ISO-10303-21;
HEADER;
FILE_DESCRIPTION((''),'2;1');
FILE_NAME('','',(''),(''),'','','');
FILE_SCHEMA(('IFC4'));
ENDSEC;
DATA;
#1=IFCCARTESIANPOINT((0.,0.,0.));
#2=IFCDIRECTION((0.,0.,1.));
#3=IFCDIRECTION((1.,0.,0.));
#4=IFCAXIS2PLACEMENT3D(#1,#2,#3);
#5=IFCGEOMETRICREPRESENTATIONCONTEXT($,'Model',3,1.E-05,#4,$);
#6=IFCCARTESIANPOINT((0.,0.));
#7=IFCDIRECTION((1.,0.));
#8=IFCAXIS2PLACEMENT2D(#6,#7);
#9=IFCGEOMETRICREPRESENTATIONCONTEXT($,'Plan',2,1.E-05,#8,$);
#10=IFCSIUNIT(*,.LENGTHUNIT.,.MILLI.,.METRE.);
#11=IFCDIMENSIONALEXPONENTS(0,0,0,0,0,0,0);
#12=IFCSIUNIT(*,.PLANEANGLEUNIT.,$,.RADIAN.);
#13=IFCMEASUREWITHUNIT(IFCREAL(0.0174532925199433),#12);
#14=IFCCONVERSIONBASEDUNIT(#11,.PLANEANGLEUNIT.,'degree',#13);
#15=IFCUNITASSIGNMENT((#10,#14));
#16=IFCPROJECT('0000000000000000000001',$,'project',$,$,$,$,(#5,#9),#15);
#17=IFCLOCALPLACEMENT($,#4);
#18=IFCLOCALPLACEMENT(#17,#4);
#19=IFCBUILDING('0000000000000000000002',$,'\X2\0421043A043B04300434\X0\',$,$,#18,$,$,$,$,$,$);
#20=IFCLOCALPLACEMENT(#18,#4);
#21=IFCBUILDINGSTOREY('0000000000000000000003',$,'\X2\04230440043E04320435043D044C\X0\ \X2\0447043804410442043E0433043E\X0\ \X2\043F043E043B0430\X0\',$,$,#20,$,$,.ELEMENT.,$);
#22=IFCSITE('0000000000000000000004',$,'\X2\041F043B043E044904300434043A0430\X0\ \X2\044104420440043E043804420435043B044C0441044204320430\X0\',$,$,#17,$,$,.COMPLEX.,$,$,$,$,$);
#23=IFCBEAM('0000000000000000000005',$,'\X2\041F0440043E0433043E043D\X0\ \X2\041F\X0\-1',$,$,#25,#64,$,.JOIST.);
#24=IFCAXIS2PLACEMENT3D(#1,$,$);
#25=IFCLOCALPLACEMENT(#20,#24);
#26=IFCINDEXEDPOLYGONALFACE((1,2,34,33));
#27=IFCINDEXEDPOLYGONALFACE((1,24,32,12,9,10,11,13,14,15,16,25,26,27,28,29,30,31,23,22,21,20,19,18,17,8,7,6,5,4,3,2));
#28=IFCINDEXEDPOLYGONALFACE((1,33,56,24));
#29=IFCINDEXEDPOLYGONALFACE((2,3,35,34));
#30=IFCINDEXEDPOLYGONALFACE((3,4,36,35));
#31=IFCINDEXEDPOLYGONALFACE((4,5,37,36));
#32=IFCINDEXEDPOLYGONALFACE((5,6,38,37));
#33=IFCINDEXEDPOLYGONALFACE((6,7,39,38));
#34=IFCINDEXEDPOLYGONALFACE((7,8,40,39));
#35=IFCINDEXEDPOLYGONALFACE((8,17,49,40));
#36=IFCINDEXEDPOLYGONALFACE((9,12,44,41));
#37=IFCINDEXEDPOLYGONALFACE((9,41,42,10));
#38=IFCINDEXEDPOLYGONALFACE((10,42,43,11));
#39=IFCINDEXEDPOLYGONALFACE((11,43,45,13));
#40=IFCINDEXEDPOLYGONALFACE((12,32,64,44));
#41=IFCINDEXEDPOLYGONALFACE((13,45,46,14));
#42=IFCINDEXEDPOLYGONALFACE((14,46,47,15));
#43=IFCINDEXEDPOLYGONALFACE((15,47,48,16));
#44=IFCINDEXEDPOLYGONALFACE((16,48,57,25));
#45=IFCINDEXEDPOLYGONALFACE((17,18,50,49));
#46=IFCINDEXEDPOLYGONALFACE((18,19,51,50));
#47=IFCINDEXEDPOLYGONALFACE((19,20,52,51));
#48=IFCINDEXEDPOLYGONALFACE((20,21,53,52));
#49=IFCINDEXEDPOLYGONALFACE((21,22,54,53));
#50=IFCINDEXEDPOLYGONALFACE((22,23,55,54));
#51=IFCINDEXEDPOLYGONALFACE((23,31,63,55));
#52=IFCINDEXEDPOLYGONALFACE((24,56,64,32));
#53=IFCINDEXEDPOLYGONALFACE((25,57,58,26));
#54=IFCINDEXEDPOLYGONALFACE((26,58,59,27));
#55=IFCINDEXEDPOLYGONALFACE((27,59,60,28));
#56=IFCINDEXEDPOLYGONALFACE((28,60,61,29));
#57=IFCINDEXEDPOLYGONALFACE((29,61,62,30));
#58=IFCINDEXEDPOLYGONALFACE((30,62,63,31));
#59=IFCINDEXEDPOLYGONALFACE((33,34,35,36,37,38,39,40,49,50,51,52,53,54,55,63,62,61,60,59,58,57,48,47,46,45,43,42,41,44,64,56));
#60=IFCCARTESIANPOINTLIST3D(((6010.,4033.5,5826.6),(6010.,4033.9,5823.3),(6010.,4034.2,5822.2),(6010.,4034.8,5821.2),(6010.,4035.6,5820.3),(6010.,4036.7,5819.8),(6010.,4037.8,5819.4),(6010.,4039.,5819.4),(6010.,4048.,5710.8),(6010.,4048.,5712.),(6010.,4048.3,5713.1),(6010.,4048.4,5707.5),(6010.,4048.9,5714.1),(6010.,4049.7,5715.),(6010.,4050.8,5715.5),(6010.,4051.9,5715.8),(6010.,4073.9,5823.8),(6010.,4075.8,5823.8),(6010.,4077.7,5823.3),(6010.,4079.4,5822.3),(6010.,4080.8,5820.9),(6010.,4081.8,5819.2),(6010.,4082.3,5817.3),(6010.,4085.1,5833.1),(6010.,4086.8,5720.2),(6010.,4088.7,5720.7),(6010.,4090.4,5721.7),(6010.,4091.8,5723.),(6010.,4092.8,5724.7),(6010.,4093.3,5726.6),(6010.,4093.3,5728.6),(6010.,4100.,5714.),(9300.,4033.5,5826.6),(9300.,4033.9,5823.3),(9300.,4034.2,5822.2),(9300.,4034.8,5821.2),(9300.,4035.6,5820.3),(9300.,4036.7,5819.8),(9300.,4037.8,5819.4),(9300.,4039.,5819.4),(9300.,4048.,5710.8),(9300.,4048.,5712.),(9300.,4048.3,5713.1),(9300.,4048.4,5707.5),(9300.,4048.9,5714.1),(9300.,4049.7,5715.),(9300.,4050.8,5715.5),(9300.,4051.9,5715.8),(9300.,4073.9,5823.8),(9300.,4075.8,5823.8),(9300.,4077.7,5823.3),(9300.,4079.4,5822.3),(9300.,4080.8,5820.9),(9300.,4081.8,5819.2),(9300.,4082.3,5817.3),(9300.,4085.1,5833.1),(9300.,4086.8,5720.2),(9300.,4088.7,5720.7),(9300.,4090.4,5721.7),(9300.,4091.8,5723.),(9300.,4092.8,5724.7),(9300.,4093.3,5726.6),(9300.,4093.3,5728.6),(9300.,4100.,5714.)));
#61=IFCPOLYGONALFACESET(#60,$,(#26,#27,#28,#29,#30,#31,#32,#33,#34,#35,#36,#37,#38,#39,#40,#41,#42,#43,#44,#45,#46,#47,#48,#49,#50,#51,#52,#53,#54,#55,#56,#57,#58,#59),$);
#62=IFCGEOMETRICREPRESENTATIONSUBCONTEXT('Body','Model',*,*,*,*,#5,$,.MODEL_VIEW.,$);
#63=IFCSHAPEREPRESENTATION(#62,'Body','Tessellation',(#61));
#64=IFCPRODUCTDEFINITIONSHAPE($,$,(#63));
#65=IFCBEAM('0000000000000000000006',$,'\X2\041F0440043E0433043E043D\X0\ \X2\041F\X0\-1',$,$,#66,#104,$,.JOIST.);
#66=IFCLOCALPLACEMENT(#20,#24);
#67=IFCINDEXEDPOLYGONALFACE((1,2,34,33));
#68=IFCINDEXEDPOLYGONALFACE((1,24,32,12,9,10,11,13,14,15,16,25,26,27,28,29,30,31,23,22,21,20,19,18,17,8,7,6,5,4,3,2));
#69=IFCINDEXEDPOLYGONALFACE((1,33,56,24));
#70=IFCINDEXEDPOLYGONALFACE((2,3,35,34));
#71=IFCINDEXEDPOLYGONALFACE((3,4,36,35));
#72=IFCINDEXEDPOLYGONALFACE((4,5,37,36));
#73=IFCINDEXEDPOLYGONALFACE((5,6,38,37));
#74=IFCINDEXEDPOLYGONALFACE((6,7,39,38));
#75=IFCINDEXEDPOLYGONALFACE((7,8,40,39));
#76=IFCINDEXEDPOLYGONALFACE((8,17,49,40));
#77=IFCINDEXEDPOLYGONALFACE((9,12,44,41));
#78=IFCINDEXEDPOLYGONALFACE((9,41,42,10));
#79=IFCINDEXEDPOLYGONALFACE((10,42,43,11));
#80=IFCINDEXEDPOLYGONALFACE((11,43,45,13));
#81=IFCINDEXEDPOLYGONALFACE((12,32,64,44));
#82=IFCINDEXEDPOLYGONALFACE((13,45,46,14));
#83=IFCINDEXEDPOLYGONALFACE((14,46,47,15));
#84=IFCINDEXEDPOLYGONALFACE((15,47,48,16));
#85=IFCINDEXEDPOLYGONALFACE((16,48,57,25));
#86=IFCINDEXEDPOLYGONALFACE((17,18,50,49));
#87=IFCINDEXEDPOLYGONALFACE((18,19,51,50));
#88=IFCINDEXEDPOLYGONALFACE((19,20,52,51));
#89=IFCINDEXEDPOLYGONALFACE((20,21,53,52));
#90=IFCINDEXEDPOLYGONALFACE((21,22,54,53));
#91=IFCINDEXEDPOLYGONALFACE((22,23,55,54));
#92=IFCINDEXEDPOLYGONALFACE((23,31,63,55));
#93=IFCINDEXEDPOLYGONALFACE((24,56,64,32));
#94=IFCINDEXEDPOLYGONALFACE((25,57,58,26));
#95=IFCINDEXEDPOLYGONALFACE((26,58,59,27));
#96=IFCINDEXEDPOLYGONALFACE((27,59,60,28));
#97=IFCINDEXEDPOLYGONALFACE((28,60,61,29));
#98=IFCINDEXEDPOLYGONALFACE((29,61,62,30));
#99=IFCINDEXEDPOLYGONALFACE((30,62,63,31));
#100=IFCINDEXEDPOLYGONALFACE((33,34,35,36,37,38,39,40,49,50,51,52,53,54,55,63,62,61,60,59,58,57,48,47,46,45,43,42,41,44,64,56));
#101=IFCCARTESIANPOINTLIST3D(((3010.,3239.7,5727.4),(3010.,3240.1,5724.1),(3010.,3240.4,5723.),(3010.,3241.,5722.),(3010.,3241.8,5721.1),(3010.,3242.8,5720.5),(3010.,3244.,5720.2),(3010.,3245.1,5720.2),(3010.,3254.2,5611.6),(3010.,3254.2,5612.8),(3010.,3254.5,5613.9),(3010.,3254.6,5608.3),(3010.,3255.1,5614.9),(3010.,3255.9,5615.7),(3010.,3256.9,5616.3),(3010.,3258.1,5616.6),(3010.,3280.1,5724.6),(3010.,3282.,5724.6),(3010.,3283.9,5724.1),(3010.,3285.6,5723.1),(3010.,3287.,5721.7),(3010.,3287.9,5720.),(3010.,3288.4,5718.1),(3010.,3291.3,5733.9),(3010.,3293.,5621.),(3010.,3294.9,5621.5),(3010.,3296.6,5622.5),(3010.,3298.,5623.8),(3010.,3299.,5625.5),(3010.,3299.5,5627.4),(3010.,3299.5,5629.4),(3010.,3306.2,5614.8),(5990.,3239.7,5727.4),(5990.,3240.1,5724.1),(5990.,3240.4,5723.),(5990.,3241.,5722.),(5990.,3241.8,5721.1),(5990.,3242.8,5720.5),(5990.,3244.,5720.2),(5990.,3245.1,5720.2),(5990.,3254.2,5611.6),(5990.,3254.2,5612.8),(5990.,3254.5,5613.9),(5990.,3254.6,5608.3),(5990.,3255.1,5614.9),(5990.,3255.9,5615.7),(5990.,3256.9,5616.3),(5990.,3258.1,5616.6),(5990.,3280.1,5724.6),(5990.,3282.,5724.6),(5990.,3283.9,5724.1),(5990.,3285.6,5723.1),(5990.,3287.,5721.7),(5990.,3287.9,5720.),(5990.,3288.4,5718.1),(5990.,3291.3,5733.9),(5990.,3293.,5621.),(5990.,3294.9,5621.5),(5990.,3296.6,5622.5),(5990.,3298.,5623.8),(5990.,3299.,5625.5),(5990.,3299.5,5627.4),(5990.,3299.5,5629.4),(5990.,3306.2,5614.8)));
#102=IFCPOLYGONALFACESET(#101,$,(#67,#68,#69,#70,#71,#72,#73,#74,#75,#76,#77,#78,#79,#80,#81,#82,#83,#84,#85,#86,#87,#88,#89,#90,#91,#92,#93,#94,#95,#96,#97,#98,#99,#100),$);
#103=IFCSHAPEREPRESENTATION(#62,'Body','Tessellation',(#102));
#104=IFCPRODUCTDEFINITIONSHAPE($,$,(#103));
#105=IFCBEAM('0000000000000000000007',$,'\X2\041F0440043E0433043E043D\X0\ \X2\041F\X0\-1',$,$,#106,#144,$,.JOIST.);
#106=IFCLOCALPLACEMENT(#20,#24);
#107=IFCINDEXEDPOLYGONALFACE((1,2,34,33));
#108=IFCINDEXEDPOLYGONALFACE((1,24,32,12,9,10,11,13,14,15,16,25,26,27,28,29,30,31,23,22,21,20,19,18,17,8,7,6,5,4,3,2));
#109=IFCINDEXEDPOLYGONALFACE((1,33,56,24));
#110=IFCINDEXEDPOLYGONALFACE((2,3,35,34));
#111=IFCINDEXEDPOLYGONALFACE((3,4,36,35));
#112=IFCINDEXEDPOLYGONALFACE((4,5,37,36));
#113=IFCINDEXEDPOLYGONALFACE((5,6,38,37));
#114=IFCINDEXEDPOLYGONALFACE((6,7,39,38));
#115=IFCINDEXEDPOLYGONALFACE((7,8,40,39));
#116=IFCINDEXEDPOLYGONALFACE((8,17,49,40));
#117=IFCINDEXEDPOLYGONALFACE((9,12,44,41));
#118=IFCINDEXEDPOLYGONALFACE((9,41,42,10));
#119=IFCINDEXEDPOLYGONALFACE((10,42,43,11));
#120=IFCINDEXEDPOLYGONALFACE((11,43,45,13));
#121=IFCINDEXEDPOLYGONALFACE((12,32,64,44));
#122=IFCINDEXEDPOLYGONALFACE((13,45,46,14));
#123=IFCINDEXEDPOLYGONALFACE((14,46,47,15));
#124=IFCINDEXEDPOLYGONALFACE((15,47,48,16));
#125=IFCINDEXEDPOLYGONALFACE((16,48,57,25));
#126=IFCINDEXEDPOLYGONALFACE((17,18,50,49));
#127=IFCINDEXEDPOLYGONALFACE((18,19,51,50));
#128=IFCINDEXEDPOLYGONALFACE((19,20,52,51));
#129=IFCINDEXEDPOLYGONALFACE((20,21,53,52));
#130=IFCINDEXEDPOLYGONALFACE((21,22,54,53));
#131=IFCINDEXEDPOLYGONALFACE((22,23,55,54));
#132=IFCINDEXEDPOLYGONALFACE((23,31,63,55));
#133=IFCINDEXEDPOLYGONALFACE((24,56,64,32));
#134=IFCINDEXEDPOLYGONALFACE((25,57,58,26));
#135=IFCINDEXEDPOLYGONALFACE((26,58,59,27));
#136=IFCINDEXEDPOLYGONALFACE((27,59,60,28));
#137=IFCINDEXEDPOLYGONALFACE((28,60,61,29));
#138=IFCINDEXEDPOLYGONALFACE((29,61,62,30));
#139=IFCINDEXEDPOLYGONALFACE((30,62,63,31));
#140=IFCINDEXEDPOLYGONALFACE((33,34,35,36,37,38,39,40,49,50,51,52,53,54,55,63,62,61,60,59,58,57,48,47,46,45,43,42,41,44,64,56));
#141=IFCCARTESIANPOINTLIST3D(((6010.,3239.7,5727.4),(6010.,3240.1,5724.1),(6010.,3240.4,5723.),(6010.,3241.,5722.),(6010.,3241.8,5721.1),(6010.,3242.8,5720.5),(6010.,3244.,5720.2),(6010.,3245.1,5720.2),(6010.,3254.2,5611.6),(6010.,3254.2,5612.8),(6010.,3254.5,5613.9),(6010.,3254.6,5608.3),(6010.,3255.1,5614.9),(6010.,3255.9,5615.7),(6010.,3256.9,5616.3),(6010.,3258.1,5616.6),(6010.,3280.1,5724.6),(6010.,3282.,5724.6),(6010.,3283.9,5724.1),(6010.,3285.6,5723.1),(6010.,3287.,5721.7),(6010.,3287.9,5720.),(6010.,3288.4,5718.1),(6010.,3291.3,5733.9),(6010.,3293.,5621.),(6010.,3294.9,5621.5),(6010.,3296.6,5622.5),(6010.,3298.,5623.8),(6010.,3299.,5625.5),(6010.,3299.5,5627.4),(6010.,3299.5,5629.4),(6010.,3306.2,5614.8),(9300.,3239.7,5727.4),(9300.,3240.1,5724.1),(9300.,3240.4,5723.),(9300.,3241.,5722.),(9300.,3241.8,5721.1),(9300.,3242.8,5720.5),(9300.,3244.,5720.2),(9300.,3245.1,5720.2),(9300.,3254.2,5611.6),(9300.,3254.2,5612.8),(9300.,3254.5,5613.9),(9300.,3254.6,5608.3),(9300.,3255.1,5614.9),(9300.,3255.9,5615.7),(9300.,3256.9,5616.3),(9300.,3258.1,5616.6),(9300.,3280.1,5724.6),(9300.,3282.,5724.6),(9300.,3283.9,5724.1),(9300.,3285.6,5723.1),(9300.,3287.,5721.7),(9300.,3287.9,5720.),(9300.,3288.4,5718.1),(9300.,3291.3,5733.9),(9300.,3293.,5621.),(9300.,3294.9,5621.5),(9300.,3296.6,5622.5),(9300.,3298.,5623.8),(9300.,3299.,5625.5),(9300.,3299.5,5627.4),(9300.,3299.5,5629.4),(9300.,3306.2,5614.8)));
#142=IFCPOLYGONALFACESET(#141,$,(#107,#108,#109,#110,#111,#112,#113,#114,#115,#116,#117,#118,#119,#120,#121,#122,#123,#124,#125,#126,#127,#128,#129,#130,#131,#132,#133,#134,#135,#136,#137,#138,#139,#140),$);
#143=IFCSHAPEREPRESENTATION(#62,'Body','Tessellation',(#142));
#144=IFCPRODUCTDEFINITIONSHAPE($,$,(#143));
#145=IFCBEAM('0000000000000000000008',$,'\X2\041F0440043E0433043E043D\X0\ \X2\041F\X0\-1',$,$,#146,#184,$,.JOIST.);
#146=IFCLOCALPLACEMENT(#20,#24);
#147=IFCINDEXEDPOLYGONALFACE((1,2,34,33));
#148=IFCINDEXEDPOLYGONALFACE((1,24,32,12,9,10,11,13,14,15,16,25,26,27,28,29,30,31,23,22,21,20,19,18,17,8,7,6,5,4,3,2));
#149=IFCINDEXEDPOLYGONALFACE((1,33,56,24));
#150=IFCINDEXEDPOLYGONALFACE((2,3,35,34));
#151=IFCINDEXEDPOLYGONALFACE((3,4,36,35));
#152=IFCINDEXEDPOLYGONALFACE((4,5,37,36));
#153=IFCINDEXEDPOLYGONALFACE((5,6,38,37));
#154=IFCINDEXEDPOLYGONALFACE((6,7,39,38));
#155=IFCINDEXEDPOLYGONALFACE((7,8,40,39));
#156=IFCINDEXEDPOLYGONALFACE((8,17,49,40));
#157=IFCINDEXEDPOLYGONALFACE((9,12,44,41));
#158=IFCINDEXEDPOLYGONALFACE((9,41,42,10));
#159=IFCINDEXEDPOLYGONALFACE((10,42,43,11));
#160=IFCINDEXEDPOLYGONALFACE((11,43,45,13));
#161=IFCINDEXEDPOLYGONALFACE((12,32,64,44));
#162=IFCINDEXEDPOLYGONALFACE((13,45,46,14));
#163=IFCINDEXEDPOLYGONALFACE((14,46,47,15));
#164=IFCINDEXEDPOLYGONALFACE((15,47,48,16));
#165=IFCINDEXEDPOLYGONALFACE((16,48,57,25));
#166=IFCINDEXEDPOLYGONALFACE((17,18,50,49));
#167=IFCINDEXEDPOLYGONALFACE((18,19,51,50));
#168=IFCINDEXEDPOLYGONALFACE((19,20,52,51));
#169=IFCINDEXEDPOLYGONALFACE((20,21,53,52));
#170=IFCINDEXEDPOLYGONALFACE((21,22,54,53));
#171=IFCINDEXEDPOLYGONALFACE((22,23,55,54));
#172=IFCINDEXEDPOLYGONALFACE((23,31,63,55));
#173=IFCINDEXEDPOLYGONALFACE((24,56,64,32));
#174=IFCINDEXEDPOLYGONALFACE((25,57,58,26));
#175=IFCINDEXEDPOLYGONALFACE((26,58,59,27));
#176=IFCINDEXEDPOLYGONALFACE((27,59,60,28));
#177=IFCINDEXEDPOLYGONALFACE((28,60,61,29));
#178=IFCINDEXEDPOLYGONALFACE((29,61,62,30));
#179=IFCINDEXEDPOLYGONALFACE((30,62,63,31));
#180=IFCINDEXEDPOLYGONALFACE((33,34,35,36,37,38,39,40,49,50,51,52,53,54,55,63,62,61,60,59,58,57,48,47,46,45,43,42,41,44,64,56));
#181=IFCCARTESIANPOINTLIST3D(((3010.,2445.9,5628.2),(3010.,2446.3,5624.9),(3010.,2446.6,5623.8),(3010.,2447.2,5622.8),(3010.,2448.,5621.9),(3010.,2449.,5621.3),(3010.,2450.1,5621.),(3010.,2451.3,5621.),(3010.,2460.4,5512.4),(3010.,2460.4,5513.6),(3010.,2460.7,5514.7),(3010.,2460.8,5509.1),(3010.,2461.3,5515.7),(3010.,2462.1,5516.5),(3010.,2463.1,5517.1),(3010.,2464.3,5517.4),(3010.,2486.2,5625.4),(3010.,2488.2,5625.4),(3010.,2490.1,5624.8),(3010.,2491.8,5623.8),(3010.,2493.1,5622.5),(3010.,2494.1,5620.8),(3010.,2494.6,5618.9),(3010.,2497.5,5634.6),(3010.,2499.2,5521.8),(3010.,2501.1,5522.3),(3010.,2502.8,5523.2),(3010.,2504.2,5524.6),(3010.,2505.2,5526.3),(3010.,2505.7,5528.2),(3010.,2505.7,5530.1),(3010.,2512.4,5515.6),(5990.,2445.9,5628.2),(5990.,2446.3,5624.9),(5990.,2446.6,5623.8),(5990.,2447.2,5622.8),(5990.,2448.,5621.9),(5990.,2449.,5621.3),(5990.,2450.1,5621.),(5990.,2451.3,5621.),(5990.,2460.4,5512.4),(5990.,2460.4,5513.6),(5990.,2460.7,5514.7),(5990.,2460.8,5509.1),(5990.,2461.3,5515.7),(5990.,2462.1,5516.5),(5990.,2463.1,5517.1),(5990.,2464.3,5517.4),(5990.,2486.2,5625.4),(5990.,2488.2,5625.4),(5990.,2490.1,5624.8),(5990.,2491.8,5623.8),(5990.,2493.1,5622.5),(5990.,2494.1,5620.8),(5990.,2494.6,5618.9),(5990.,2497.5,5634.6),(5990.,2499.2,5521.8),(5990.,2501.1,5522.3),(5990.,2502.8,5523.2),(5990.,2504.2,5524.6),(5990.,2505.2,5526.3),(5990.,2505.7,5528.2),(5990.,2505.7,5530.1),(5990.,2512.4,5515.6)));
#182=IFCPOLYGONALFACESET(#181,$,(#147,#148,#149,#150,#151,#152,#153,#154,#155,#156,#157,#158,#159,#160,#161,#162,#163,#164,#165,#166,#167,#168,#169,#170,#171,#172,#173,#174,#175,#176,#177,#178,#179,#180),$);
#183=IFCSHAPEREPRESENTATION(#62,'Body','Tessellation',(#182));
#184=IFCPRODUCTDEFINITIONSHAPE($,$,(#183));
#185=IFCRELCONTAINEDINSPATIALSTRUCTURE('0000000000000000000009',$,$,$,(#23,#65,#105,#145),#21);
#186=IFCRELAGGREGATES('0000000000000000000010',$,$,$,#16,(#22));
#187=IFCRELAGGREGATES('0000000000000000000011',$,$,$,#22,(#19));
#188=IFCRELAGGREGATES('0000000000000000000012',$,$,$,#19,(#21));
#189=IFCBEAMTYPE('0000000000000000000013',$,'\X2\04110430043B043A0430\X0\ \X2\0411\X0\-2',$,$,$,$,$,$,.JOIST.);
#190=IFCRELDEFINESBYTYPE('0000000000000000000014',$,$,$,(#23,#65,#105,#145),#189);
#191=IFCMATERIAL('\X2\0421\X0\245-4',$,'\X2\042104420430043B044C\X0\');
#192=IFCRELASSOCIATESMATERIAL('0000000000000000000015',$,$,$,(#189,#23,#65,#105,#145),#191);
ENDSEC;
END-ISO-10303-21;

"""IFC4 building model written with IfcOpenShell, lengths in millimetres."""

from ifc_helpers import new_model, entity, si_unit, converted_unit, frame, origin_with_axes, origin_2d_with_axis, place, context, subcontext, project, spatial, u_section, extrude, material, material_profile, profile_set, profile_usage, type_object, element, save


model = new_model("IFC4")

# Units and contexts
model_context = context("Model", 3, precision=1e-05, world=origin_with_axes())
plan_context = context("Plan", 2, precision=1e-05, world=origin_2d_with_axis())
body_context = subcontext(model_context, "Body", "Model", "MODEL_VIEW")
ifc_project = project(units=[si_unit("LENGTHUNIT", "METRE", prefix="MILLI"), converted_unit("PLANEANGLEUNIT", "degree", entity("IfcReal", 0.0174532925199433), si_unit("PLANEANGLEUNIT", "RADIAN"), dimensions=[0, 0, 0, 0, 0, 0, 0])], contexts=[model_context, plan_context])

# Site, building, storey
site_placement = place(None, origin_with_axes())
site = spatial("IfcSite", under=ifc_project, at=site_placement, Name="Площадка строительства", CompositionType="COMPLEX")
building_placement = place(site_placement, origin_with_axes())
building = spatial("IfcBuilding", under=site, at=building_placement, Name="Склад")
storey_placement = place(building_placement, origin_with_axes())
storey = spatial("IfcBuildingStorey", under=building, at=storey_placement, Name="Уровень чистого пола", CompositionType="ELEMENT")

# Beams
ifc_material_1 = material(Name="С245-4", Category="Сталь")
ifc_material_profile_1 = material_profile(ifc_material_1, u_section(Depth=120.0, FlangeWidth=52.0, WebThickness=4.8, FlangeThickness=7.8, FilletRadius=7.5, EdgeRadius=4.5, FlangeSlope=0.0))
ifc_profile_set_1 = profile_set([ifc_material_profile_1], Name="U12P_S245-4")
beam_type_1 = type_object("IfcBeamType", Name="Балка Б-2", PredefinedType="JOIST", material=ifc_profile_set_1)
ifc_profile_usage_1 = profile_usage(ifc_profile_set_1, cardinal=3)
beam_1_placement = place(storey_placement, frame((9300.0, 4100.0, 5714.0), z_axis=(-1.0, 0.0, 0.0), x_axis=(0.0, -0.99228, -0.12402)))
element("IfcBeam", 1, at=beam_1_placement, inside=storey, type_object=beam_type_1, material=ifc_profile_usage_1, Name="Прогон П-1", PredefinedType="JOIST", context=body_context, shape_type="SweptSolid", body=[
    extrude(u_section(Depth=120.0, FlangeWidth=52.0, WebThickness=4.8, FlangeThickness=7.8, FilletRadius=7.5, EdgeRadius=4.5, FlangeSlope=0.0), frame((26.0, 60.0, 0.0), z_axis=(0.0, 0.0, 1.0), x_axis=(1.0, 0.0, 0.0)), (0.0, 0.0, 1.0), 3290.0),
])
ifc_profile_usage_2 = profile_usage(ifc_profile_set_1, cardinal=3)
beam_2_placement = place(storey_placement, frame((5990.0, 3306.2, 5614.8), z_axis=(-1.0, 0.0, 0.0), x_axis=(0.0, -0.99228, -0.12402)))
element("IfcBeam", 2, at=beam_2_placement, inside=storey, type_object=beam_type_1, material=ifc_profile_usage_2, Name="Прогон П-1", PredefinedType="JOIST", context=body_context, shape_type="SweptSolid", body=[
    extrude(u_section(Depth=120.0, FlangeWidth=52.0, WebThickness=4.8, FlangeThickness=7.8, FilletRadius=7.5, EdgeRadius=4.5, FlangeSlope=0.0), frame((26.0, 60.0, 0.0), z_axis=(0.0, 0.0, 1.0), x_axis=(1.0, 0.0, 0.0)), (0.0, 0.0, 1.0), 2980.0),
])
ifc_profile_usage_3 = profile_usage(ifc_profile_set_1, cardinal=3)
beam_3_placement = place(storey_placement, frame((9300.0, 3306.2, 5614.8), z_axis=(-1.0, 0.0, 0.0), x_axis=(0.0, -0.99228, -0.12402)))
element("IfcBeam", 3, at=beam_3_placement, inside=storey, type_object=beam_type_1, material=ifc_profile_usage_3, Name="Прогон П-1", PredefinedType="JOIST", context=body_context, shape_type="SweptSolid", body=[
    extrude(u_section(Depth=120.0, FlangeWidth=52.0, WebThickness=4.8, FlangeThickness=7.8, FilletRadius=7.5, EdgeRadius=4.5, FlangeSlope=0.0), frame((26.0, 60.0, 0.0), z_axis=(0.0, 0.0, 1.0), x_axis=(1.0, 0.0, 0.0)), (0.0, 0.0, 1.0), 3290.0),
])
ifc_profile_usage_4 = profile_usage(ifc_profile_set_1, cardinal=3)
beam_4_placement = place(storey_placement, frame((5990.0, 2512.4, 5515.6), z_axis=(-1.0, 0.0, 0.0), x_axis=(0.0, -0.99228, -0.12402)))
element("IfcBeam", 4, at=beam_4_placement, inside=storey, type_object=beam_type_1, material=ifc_profile_usage_4, Name="Прогон П-1", PredefinedType="JOIST", context=body_context, shape_type="SweptSolid", body=[
    extrude(u_section(Depth=120.0, FlangeWidth=52.0, WebThickness=4.8, FlangeThickness=7.8, FilletRadius=7.5, EdgeRadius=4.5, FlangeSlope=0.0), frame((26.0, 60.0, 0.0), z_axis=(0.0, 0.0, 1.0), x_axis=(1.0, 0.0, 0.0)), (0.0, 0.0, 1.0), 2980.0),
])

save(model, "model.ifc")
